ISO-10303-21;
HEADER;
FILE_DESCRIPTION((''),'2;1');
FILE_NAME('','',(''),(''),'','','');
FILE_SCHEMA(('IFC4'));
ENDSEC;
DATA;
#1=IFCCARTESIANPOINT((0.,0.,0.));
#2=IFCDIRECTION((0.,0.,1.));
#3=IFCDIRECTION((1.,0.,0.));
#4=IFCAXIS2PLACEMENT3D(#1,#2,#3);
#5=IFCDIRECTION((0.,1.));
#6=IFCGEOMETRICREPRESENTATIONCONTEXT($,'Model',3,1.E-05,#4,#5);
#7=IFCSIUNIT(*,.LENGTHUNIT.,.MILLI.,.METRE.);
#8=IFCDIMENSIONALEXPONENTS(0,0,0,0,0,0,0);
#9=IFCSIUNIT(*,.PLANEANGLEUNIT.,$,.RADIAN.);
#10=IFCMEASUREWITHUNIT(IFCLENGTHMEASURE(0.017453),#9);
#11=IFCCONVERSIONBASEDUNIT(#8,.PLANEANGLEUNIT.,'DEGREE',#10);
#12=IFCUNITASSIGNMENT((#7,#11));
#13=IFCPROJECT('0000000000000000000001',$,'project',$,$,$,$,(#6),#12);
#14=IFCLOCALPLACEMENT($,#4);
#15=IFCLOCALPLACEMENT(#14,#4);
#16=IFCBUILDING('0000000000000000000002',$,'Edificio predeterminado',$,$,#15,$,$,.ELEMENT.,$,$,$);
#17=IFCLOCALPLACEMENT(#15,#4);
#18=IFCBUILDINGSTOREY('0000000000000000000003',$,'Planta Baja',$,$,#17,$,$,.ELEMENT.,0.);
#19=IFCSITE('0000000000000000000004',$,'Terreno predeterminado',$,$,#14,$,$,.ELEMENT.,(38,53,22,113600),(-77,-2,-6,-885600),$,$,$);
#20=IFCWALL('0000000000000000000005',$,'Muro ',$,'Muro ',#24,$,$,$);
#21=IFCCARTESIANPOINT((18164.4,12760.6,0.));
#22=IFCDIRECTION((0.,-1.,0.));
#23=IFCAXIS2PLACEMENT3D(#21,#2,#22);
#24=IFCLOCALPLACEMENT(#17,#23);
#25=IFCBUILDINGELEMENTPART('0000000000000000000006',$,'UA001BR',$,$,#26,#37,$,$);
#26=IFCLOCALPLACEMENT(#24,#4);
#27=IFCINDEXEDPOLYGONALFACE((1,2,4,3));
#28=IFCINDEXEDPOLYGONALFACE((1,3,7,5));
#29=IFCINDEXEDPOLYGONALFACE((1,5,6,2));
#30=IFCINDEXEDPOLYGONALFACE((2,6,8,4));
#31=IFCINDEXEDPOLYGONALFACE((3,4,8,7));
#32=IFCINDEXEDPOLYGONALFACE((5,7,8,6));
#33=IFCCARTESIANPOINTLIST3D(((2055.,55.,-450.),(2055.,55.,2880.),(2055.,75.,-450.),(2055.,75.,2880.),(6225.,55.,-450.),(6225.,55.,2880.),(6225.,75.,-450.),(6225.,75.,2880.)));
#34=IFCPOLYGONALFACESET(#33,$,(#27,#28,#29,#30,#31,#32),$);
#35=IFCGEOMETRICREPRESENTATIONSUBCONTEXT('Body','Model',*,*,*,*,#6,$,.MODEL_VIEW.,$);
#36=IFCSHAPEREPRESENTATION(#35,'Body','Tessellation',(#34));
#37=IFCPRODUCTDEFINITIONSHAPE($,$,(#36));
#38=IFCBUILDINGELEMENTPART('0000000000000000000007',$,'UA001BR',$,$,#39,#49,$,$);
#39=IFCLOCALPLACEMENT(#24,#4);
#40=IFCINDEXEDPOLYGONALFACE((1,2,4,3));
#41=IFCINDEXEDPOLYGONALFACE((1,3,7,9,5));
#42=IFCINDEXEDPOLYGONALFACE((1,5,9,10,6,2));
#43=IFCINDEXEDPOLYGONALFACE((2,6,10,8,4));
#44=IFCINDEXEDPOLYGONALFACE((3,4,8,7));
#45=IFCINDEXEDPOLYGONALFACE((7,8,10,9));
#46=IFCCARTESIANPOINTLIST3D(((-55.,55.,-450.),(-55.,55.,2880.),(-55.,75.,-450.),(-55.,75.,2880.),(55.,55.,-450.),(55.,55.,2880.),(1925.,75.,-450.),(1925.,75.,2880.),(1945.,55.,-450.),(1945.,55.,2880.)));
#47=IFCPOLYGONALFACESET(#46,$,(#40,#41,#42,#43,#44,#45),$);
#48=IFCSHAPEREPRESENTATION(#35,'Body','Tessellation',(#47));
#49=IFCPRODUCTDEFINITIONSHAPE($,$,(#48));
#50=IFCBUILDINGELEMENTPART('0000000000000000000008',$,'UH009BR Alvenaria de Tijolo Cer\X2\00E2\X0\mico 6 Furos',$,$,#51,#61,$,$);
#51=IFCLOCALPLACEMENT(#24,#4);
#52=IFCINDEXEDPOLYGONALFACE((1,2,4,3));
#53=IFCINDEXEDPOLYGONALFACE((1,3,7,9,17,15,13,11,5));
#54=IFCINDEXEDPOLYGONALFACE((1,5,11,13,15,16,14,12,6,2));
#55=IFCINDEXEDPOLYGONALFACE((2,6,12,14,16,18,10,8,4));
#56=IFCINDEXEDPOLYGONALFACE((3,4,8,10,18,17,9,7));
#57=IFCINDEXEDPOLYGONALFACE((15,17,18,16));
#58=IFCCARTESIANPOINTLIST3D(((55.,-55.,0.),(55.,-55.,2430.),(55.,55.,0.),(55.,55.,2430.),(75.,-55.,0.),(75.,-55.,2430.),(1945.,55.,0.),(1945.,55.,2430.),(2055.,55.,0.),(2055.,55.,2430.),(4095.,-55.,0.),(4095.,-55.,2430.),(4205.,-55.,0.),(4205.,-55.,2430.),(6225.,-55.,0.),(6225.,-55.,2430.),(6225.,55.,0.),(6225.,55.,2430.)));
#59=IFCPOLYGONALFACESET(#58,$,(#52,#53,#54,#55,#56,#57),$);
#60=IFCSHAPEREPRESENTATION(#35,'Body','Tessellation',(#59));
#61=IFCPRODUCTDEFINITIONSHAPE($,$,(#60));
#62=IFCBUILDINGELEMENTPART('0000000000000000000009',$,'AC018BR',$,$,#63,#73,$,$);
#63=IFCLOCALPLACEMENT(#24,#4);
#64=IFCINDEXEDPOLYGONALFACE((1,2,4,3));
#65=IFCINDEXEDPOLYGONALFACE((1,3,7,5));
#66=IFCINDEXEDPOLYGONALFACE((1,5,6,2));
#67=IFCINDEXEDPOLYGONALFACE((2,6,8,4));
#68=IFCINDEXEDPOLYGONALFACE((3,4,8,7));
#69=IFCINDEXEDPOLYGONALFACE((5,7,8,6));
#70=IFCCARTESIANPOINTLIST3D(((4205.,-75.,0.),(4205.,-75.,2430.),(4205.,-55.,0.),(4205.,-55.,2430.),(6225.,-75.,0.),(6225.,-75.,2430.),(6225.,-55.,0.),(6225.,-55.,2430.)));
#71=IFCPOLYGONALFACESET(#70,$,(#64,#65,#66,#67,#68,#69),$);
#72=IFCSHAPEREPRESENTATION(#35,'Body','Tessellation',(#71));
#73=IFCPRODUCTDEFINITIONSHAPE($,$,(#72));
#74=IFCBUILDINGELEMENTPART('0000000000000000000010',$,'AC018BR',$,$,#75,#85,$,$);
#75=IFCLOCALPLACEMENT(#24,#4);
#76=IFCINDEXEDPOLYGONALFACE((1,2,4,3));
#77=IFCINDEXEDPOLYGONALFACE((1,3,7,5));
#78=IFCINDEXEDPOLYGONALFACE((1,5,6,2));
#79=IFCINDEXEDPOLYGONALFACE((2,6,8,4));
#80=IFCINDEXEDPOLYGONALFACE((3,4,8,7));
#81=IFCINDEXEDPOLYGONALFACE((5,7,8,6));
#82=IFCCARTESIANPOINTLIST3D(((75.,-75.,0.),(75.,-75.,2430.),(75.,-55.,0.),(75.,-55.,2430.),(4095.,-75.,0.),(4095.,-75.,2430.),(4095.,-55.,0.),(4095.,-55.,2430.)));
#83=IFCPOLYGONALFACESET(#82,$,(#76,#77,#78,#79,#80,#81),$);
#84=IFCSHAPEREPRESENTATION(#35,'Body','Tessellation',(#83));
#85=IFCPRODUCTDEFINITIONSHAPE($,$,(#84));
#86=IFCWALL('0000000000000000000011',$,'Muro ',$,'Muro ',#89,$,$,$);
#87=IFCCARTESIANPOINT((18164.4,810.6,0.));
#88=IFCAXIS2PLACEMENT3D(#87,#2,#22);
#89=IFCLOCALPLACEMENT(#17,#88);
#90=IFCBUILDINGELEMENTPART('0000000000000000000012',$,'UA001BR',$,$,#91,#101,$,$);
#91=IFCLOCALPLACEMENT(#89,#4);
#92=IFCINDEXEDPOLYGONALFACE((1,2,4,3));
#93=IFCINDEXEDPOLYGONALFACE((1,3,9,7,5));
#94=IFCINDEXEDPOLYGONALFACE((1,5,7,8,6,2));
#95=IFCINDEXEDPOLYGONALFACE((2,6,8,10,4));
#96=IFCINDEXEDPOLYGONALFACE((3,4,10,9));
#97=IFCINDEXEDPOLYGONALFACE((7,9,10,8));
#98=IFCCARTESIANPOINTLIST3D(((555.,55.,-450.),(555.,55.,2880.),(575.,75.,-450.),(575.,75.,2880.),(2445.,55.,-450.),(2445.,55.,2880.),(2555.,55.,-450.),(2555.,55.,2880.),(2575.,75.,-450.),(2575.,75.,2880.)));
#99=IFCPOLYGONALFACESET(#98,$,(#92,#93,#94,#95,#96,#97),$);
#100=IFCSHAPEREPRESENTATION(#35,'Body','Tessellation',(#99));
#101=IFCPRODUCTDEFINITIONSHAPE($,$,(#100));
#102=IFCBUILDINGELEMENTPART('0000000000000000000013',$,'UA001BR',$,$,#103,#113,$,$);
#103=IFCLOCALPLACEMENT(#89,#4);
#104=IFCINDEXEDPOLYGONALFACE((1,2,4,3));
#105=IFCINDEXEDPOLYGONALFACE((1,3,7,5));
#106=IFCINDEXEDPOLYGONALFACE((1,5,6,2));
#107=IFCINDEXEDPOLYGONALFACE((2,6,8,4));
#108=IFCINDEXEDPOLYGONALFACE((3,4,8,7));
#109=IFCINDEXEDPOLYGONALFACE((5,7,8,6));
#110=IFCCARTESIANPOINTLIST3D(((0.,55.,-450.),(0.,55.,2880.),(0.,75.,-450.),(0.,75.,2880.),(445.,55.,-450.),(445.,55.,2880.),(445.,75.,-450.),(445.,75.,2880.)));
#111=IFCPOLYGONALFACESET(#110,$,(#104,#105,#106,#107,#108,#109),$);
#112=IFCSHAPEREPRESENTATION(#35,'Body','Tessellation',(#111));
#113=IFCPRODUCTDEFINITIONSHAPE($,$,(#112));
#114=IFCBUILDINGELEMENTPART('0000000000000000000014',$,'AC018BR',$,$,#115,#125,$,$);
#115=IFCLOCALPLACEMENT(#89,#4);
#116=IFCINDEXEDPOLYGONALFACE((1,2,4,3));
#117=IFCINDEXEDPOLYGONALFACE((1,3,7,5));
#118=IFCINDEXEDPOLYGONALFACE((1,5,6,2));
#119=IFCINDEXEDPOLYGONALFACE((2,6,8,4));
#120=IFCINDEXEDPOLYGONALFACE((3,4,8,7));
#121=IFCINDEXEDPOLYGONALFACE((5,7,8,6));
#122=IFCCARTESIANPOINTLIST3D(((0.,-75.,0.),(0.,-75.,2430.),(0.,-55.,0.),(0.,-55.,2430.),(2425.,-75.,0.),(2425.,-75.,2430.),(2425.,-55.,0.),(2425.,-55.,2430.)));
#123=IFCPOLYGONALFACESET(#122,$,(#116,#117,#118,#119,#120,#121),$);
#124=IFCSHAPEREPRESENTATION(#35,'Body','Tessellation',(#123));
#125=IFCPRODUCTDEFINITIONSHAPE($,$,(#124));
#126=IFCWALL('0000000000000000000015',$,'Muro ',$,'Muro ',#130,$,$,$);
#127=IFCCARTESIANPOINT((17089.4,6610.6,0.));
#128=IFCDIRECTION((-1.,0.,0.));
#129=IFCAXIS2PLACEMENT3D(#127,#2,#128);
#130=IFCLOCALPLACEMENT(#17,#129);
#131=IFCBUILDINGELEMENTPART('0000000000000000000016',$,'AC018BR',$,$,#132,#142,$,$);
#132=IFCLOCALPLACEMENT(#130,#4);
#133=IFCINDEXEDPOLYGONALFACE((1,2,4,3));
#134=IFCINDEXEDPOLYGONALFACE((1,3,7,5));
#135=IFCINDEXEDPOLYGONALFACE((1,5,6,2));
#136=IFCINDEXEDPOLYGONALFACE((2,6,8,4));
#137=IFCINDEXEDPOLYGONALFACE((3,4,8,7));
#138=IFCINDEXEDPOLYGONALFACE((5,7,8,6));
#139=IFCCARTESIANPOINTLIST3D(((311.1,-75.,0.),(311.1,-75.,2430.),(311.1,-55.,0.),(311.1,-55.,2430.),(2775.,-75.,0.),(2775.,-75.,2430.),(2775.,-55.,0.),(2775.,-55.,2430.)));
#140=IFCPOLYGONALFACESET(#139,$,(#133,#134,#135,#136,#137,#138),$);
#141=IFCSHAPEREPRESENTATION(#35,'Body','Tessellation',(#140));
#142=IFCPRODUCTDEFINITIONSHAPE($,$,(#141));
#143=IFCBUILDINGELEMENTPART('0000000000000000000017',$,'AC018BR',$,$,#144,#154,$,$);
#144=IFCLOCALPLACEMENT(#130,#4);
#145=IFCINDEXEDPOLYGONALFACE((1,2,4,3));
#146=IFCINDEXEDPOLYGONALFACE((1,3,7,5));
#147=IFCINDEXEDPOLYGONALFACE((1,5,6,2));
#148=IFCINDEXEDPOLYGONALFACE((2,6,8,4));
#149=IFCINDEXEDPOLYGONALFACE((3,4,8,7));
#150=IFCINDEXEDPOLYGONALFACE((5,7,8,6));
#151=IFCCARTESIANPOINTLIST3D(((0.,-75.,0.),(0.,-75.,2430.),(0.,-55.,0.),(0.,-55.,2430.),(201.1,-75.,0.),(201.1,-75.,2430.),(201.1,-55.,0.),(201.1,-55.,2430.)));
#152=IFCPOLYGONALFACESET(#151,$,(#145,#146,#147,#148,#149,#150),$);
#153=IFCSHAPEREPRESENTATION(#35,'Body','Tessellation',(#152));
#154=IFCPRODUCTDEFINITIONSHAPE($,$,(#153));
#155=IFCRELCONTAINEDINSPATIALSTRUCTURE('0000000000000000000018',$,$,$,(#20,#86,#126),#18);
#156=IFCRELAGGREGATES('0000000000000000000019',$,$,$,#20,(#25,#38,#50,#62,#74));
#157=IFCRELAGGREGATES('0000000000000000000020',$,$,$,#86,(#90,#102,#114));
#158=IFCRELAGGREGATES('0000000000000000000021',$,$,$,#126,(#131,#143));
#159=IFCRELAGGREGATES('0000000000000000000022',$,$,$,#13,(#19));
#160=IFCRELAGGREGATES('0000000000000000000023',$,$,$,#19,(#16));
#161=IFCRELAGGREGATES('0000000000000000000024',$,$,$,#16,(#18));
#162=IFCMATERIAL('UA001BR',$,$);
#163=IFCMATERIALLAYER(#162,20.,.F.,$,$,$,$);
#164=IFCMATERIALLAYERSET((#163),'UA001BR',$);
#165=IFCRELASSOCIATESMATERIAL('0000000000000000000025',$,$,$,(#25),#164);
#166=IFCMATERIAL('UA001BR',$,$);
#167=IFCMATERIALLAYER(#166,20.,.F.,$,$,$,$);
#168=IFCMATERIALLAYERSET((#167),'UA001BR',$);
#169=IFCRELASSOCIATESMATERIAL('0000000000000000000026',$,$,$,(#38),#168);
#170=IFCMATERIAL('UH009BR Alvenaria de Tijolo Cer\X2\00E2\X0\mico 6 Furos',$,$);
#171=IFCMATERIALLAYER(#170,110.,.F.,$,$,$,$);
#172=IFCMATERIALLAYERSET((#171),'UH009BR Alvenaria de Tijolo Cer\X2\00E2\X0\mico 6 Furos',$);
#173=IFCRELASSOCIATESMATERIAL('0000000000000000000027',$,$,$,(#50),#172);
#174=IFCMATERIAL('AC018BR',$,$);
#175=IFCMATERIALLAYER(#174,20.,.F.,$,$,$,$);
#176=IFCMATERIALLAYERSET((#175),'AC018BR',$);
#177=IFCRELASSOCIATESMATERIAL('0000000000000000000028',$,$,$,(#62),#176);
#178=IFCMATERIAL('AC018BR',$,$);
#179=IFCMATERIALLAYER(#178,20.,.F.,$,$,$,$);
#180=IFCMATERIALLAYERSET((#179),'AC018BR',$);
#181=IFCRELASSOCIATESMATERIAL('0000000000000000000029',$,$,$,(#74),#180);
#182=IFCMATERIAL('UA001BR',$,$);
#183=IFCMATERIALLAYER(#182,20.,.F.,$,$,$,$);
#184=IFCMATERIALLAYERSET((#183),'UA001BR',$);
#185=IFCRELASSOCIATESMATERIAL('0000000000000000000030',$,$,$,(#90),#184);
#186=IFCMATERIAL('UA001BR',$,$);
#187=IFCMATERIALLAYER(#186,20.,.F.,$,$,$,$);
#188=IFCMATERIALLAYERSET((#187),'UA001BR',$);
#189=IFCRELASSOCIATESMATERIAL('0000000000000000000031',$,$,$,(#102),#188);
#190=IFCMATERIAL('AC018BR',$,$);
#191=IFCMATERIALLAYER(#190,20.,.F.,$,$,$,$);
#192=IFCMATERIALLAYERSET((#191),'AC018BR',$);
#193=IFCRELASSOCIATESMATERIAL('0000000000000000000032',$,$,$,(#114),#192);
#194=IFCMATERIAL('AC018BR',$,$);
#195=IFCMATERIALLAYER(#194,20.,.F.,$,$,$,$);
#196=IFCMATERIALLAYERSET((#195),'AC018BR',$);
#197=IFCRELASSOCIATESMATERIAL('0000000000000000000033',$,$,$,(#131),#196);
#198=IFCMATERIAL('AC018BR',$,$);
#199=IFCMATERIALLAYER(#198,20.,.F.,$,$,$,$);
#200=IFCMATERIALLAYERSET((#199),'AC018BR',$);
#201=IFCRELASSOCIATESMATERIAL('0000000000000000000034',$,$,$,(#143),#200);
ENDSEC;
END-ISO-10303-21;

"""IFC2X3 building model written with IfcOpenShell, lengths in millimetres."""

from ifc_helpers import new_model, entity, si_unit, converted_unit, direction, frame, origin_with_axes, place, context, subcontext, project, spatial, polyline, outline, extrude, material, layer, layer_set, layer_usage, element, aggregate, save


model = new_model("IFC2X3")

# Units and contexts
model_context = context("Model", 3, precision=1e-05, world=origin_with_axes(), true_north=direction((0.0, 1.0)))
body_context = subcontext(model_context, "Body", "Model", "MODEL_VIEW")
ifc_project = project(units=[si_unit("LENGTHUNIT", "METRE", prefix="MILLI"), converted_unit("PLANEANGLEUNIT", "DEGREE", entity("IfcLengthMeasure", 0.017453), si_unit("PLANEANGLEUNIT", "RADIAN"), dimensions=[0, 0, 0, 0, 0, 0, 0])], contexts=[model_context])

# Site, building, storey
site_placement = place(None, origin_with_axes())
site = spatial("IfcSite", under=ifc_project, at=site_placement, Name="Terreno predeterminado", CompositionType="ELEMENT", RefLatitude=(38, 53, 22, 113600), RefLongitude=(-77, -2, -6, -885600))
building_placement = place(site_placement, origin_with_axes())
building = spatial("IfcBuilding", under=site, at=building_placement, Name="Edificio predeterminado", CompositionType="ELEMENT")
storey_placement = place(building_placement, origin_with_axes())
storey = spatial("IfcBuildingStorey", under=building, at=storey_placement, Name="Planta Baja", CompositionType="ELEMENT", Elevation=0.0)

# Walls, building element parts
wall_1_placement = place(storey_placement, frame((18164.4, 12760.6, 0.0), z_axis=(0.0, 0.0, 1.0), x_axis=(0.0, -1.0, 0.0)))
wall_1 = element("IfcWall", 1, at=wall_1_placement, inside=storey, Name="Muro ", ObjectType="Muro ")
ifc_material_1 = material(Name="UA001BR")
ifc_layer_1 = layer(ifc_material_1, 20.0, ventilated=False)
ifc_layer_set_1 = layer_set([ifc_layer_1], Name="UA001BR")
ifc_layer_usage_1 = layer_usage(ifc_layer_set_1, "AXIS2", "NEGATIVE", -75.0)
building_element_part_1_placement = place(wall_1_placement, origin_with_axes())
building_element_part_1 = element("IfcBuildingElementPart", 2, at=building_element_part_1_placement, material=ifc_layer_usage_1, Name="UA001BR", context=body_context, shape_type="SweptSolid", body=[
    extrude(outline(polyline([(6225.0, 75.0), (6225.0, 55.0), (2055.0, 55.0), (2055.0, 75.0), (6225.0, 75.0)])), frame((0.0, 0.0, -450.0), z_axis=(0.0, 0.0, 1.0), x_axis=(1.0, 0.0, 0.0)), (0.0, 0.0, 1.0), 3330.0),
])
ifc_material_2 = material(Name="UA001BR")
ifc_layer_2 = layer(ifc_material_2, 20.0, ventilated=False)
ifc_layer_set_2 = layer_set([ifc_layer_2], Name="UA001BR")
ifc_layer_usage_2 = layer_usage(ifc_layer_set_2, "AXIS2", "NEGATIVE", -75.0)
building_element_part_2_placement = place(wall_1_placement, origin_with_axes())
building_element_part_2 = element("IfcBuildingElementPart", 3, at=building_element_part_2_placement, material=ifc_layer_usage_2, Name="UA001BR", context=body_context, shape_type="SweptSolid", body=[
    extrude(outline(polyline([(1925.0, 75.0), (1945.0, 55.0), (55.0, 55.0), (-55.0, 55.0), (-55.0, 75.0), (1925.0, 75.0)])), frame((0.0, 0.0, -450.0), z_axis=(0.0, 0.0, 1.0), x_axis=(1.0, 0.0, 0.0)), (0.0, 0.0, 1.0), 3330.0),
])
ifc_material_3 = material(Name="UH009BR Alvenaria de Tijolo Cerâmico 6 Furos")
ifc_layer_3 = layer(ifc_material_3, 110.0, ventilated=False)
ifc_layer_set_3 = layer_set([ifc_layer_3], Name="UH009BR Alvenaria de Tijolo Cerâmico 6 Furos")
ifc_layer_usage_3 = layer_usage(ifc_layer_set_3, "AXIS2", "NEGATIVE", -55.0)
building_element_part_3_placement = place(wall_1_placement, origin_with_axes())
building_element_part_3 = element("IfcBuildingElementPart", 4, at=building_element_part_3_placement, material=ifc_layer_usage_3, Name="UH009BR Alvenaria de Tijolo Cerâmico 6 Furos", context=body_context, shape_type="SweptSolid", body=[
    extrude(outline(polyline([(6225.0, 55.0), (6225.0, -55.0), (4205.0, -55.0), (4095.0, -55.0), (75.0, -55.0), (55.0, -55.0), (55.0, 55.0), (1945.0, 55.0), (2055.0, 55.0), (6225.0, 55.0)])), origin_with_axes(), (0.0, 0.0, 1.0), 2430.0),
])
ifc_material_4 = material(Name="AC018BR")
ifc_layer_4 = layer(ifc_material_4, 20.0, ventilated=False)
ifc_layer_set_4 = layer_set([ifc_layer_4], Name="AC018BR")
ifc_layer_usage_4 = layer_usage(ifc_layer_set_4, "AXIS2", "NEGATIVE", 55.0)
building_element_part_4_placement = place(wall_1_placement, origin_with_axes())
building_element_part_4 = element("IfcBuildingElementPart", 5, at=building_element_part_4_placement, material=ifc_layer_usage_4, Name="AC018BR", context=body_context, shape_type="SweptSolid", body=[
    extrude(outline(polyline([(6225.0, -55.0), (6225.0, -75.0), (4205.0, -75.0), (4205.0, -55.0), (6225.0, -55.0)])), origin_with_axes(), (0.0, 0.0, 1.0), 2430.0),
])
ifc_material_5 = material(Name="AC018BR")
ifc_layer_5 = layer(ifc_material_5, 20.0, ventilated=False)
ifc_layer_set_5 = layer_set([ifc_layer_5], Name="AC018BR")
ifc_layer_usage_5 = layer_usage(ifc_layer_set_5, "AXIS2", "NEGATIVE", 55.0)
building_element_part_5_placement = place(wall_1_placement, origin_with_axes())
building_element_part_5 = element("IfcBuildingElementPart", 6, at=building_element_part_5_placement, material=ifc_layer_usage_5, Name="AC018BR", context=body_context, shape_type="SweptSolid", body=[
    extrude(outline(polyline([(4095.0, -55.0), (4095.0, -75.0), (75.0, -75.0), (75.0, -55.0), (4095.0, -55.0)])), origin_with_axes(), (0.0, 0.0, 1.0), 2430.0),
])
aggregate(wall_1, [building_element_part_1, building_element_part_2, building_element_part_3, building_element_part_4, building_element_part_5])
wall_2_placement = place(storey_placement, frame((18164.4, 810.6, 0.0), z_axis=(0.0, 0.0, 1.0), x_axis=(0.0, -1.0, 0.0)))
wall_2 = element("IfcWall", 7, at=wall_2_placement, inside=storey, Name="Muro ", ObjectType="Muro ")
ifc_material_6 = material(Name="UA001BR")
ifc_layer_6 = layer(ifc_material_6, 20.0, ventilated=False)
ifc_layer_set_6 = layer_set([ifc_layer_6], Name="UA001BR")
ifc_layer_usage_6 = layer_usage(ifc_layer_set_6, "AXIS2", "NEGATIVE", -75.0)
building_element_part_6_placement = place(wall_2_placement, origin_with_axes())
building_element_part_6 = element("IfcBuildingElementPart", 8, at=building_element_part_6_placement, material=ifc_layer_usage_6, Name="UA001BR", context=body_context, shape_type="SweptSolid", body=[
    extrude(outline(polyline([(2575.0, 75.0), (2555.0, 55.0), (2445.0, 55.0), (555.0, 55.0), (575.0, 75.0), (2575.0, 75.0)])), frame((0.0, 0.0, -450.0), z_axis=(0.0, 0.0, 1.0), x_axis=(1.0, 0.0, 0.0)), (0.0, 0.0, 1.0), 3330.0),
])
ifc_material_7 = material(Name="UA001BR")
ifc_layer_7 = layer(ifc_material_7, 20.0, ventilated=False)
ifc_layer_set_7 = layer_set([ifc_layer_7], Name="UA001BR")
ifc_layer_usage_7 = layer_usage(ifc_layer_set_7, "AXIS2", "NEGATIVE", -75.0)
building_element_part_7_placement = place(wall_2_placement, origin_with_axes())
building_element_part_7 = element("IfcBuildingElementPart", 9, at=building_element_part_7_placement, material=ifc_layer_usage_7, Name="UA001BR", context=body_context, shape_type="SweptSolid", body=[
    extrude(outline(polyline([(445.0, 75.0), (445.0, 55.0), (0.0, 55.0), (0.0, 75.0), (445.0, 75.0)])), frame((0.0, 0.0, -450.0), z_axis=(0.0, 0.0, 1.0), x_axis=(1.0, 0.0, 0.0)), (0.0, 0.0, 1.0), 3330.0),
])
ifc_material_8 = material(Name="AC018BR")
ifc_layer_8 = layer(ifc_material_8, 20.0, ventilated=False)
ifc_layer_set_8 = layer_set([ifc_layer_8], Name="AC018BR")
ifc_layer_usage_8 = layer_usage(ifc_layer_set_8, "AXIS2", "NEGATIVE", 55.0)
building_element_part_8_placement = place(wall_2_placement, origin_with_axes())
building_element_part_8 = element("IfcBuildingElementPart", 10, at=building_element_part_8_placement, material=ifc_layer_usage_8, Name="AC018BR", context=body_context, shape_type="SweptSolid", body=[
    extrude(outline(polyline([(2425.0, -55.0), (2425.0, -75.0), (0.0, -75.0), (0.0, -55.0), (2425.0, -55.0)])), origin_with_axes(), (0.0, 0.0, 1.0), 2430.0),
])
aggregate(wall_2, [building_element_part_6, building_element_part_7, building_element_part_8])
wall_3_placement = place(storey_placement, frame((17089.4, 6610.6, 0.0), z_axis=(0.0, 0.0, 1.0), x_axis=(-1.0, 0.0, 0.0)))
wall_3 = element("IfcWall", 11, at=wall_3_placement, inside=storey, Name="Muro ", ObjectType="Muro ")
ifc_material_9 = material(Name="AC018BR")
ifc_layer_9 = layer(ifc_material_9, 20.0, ventilated=False)
ifc_layer_set_9 = layer_set([ifc_layer_9], Name="AC018BR")
ifc_layer_usage_9 = layer_usage(ifc_layer_set_9, "AXIS2", "NEGATIVE", 55.0)
building_element_part_9_placement = place(wall_3_placement, origin_with_axes())
building_element_part_9 = element("IfcBuildingElementPart", 12, at=building_element_part_9_placement, material=ifc_layer_usage_9, Name="AC018BR", context=body_context, shape_type="SweptSolid", body=[
    extrude(outline(polyline([(2775.0, -55.0), (2775.0, -75.0), (311.1, -75.0), (311.1, -55.0), (2775.0, -55.0)])), origin_with_axes(), (0.0, 0.0, 1.0), 2430.0),
])
ifc_material_10 = material(Name="AC018BR")
ifc_layer_10 = layer(ifc_material_10, 20.0, ventilated=False)
ifc_layer_set_10 = layer_set([ifc_layer_10], Name="AC018BR")
ifc_layer_usage_10 = layer_usage(ifc_layer_set_10, "AXIS2", "NEGATIVE", 55.0)
building_element_part_10_placement = place(wall_3_placement, origin_with_axes())
building_element_part_10 = element("IfcBuildingElementPart", 13, at=building_element_part_10_placement, material=ifc_layer_usage_10, Name="AC018BR", context=body_context, shape_type="SweptSolid", body=[
    extrude(outline(polyline([(201.1, -55.0), (201.1, -75.0), (0.0, -75.0), (0.0, -55.0), (201.1, -55.0)])), origin_with_axes(), (0.0, 0.0, 1.0), 2430.0),
])
aggregate(wall_3, [building_element_part_9, building_element_part_10])

save(model, "model.ifc")
